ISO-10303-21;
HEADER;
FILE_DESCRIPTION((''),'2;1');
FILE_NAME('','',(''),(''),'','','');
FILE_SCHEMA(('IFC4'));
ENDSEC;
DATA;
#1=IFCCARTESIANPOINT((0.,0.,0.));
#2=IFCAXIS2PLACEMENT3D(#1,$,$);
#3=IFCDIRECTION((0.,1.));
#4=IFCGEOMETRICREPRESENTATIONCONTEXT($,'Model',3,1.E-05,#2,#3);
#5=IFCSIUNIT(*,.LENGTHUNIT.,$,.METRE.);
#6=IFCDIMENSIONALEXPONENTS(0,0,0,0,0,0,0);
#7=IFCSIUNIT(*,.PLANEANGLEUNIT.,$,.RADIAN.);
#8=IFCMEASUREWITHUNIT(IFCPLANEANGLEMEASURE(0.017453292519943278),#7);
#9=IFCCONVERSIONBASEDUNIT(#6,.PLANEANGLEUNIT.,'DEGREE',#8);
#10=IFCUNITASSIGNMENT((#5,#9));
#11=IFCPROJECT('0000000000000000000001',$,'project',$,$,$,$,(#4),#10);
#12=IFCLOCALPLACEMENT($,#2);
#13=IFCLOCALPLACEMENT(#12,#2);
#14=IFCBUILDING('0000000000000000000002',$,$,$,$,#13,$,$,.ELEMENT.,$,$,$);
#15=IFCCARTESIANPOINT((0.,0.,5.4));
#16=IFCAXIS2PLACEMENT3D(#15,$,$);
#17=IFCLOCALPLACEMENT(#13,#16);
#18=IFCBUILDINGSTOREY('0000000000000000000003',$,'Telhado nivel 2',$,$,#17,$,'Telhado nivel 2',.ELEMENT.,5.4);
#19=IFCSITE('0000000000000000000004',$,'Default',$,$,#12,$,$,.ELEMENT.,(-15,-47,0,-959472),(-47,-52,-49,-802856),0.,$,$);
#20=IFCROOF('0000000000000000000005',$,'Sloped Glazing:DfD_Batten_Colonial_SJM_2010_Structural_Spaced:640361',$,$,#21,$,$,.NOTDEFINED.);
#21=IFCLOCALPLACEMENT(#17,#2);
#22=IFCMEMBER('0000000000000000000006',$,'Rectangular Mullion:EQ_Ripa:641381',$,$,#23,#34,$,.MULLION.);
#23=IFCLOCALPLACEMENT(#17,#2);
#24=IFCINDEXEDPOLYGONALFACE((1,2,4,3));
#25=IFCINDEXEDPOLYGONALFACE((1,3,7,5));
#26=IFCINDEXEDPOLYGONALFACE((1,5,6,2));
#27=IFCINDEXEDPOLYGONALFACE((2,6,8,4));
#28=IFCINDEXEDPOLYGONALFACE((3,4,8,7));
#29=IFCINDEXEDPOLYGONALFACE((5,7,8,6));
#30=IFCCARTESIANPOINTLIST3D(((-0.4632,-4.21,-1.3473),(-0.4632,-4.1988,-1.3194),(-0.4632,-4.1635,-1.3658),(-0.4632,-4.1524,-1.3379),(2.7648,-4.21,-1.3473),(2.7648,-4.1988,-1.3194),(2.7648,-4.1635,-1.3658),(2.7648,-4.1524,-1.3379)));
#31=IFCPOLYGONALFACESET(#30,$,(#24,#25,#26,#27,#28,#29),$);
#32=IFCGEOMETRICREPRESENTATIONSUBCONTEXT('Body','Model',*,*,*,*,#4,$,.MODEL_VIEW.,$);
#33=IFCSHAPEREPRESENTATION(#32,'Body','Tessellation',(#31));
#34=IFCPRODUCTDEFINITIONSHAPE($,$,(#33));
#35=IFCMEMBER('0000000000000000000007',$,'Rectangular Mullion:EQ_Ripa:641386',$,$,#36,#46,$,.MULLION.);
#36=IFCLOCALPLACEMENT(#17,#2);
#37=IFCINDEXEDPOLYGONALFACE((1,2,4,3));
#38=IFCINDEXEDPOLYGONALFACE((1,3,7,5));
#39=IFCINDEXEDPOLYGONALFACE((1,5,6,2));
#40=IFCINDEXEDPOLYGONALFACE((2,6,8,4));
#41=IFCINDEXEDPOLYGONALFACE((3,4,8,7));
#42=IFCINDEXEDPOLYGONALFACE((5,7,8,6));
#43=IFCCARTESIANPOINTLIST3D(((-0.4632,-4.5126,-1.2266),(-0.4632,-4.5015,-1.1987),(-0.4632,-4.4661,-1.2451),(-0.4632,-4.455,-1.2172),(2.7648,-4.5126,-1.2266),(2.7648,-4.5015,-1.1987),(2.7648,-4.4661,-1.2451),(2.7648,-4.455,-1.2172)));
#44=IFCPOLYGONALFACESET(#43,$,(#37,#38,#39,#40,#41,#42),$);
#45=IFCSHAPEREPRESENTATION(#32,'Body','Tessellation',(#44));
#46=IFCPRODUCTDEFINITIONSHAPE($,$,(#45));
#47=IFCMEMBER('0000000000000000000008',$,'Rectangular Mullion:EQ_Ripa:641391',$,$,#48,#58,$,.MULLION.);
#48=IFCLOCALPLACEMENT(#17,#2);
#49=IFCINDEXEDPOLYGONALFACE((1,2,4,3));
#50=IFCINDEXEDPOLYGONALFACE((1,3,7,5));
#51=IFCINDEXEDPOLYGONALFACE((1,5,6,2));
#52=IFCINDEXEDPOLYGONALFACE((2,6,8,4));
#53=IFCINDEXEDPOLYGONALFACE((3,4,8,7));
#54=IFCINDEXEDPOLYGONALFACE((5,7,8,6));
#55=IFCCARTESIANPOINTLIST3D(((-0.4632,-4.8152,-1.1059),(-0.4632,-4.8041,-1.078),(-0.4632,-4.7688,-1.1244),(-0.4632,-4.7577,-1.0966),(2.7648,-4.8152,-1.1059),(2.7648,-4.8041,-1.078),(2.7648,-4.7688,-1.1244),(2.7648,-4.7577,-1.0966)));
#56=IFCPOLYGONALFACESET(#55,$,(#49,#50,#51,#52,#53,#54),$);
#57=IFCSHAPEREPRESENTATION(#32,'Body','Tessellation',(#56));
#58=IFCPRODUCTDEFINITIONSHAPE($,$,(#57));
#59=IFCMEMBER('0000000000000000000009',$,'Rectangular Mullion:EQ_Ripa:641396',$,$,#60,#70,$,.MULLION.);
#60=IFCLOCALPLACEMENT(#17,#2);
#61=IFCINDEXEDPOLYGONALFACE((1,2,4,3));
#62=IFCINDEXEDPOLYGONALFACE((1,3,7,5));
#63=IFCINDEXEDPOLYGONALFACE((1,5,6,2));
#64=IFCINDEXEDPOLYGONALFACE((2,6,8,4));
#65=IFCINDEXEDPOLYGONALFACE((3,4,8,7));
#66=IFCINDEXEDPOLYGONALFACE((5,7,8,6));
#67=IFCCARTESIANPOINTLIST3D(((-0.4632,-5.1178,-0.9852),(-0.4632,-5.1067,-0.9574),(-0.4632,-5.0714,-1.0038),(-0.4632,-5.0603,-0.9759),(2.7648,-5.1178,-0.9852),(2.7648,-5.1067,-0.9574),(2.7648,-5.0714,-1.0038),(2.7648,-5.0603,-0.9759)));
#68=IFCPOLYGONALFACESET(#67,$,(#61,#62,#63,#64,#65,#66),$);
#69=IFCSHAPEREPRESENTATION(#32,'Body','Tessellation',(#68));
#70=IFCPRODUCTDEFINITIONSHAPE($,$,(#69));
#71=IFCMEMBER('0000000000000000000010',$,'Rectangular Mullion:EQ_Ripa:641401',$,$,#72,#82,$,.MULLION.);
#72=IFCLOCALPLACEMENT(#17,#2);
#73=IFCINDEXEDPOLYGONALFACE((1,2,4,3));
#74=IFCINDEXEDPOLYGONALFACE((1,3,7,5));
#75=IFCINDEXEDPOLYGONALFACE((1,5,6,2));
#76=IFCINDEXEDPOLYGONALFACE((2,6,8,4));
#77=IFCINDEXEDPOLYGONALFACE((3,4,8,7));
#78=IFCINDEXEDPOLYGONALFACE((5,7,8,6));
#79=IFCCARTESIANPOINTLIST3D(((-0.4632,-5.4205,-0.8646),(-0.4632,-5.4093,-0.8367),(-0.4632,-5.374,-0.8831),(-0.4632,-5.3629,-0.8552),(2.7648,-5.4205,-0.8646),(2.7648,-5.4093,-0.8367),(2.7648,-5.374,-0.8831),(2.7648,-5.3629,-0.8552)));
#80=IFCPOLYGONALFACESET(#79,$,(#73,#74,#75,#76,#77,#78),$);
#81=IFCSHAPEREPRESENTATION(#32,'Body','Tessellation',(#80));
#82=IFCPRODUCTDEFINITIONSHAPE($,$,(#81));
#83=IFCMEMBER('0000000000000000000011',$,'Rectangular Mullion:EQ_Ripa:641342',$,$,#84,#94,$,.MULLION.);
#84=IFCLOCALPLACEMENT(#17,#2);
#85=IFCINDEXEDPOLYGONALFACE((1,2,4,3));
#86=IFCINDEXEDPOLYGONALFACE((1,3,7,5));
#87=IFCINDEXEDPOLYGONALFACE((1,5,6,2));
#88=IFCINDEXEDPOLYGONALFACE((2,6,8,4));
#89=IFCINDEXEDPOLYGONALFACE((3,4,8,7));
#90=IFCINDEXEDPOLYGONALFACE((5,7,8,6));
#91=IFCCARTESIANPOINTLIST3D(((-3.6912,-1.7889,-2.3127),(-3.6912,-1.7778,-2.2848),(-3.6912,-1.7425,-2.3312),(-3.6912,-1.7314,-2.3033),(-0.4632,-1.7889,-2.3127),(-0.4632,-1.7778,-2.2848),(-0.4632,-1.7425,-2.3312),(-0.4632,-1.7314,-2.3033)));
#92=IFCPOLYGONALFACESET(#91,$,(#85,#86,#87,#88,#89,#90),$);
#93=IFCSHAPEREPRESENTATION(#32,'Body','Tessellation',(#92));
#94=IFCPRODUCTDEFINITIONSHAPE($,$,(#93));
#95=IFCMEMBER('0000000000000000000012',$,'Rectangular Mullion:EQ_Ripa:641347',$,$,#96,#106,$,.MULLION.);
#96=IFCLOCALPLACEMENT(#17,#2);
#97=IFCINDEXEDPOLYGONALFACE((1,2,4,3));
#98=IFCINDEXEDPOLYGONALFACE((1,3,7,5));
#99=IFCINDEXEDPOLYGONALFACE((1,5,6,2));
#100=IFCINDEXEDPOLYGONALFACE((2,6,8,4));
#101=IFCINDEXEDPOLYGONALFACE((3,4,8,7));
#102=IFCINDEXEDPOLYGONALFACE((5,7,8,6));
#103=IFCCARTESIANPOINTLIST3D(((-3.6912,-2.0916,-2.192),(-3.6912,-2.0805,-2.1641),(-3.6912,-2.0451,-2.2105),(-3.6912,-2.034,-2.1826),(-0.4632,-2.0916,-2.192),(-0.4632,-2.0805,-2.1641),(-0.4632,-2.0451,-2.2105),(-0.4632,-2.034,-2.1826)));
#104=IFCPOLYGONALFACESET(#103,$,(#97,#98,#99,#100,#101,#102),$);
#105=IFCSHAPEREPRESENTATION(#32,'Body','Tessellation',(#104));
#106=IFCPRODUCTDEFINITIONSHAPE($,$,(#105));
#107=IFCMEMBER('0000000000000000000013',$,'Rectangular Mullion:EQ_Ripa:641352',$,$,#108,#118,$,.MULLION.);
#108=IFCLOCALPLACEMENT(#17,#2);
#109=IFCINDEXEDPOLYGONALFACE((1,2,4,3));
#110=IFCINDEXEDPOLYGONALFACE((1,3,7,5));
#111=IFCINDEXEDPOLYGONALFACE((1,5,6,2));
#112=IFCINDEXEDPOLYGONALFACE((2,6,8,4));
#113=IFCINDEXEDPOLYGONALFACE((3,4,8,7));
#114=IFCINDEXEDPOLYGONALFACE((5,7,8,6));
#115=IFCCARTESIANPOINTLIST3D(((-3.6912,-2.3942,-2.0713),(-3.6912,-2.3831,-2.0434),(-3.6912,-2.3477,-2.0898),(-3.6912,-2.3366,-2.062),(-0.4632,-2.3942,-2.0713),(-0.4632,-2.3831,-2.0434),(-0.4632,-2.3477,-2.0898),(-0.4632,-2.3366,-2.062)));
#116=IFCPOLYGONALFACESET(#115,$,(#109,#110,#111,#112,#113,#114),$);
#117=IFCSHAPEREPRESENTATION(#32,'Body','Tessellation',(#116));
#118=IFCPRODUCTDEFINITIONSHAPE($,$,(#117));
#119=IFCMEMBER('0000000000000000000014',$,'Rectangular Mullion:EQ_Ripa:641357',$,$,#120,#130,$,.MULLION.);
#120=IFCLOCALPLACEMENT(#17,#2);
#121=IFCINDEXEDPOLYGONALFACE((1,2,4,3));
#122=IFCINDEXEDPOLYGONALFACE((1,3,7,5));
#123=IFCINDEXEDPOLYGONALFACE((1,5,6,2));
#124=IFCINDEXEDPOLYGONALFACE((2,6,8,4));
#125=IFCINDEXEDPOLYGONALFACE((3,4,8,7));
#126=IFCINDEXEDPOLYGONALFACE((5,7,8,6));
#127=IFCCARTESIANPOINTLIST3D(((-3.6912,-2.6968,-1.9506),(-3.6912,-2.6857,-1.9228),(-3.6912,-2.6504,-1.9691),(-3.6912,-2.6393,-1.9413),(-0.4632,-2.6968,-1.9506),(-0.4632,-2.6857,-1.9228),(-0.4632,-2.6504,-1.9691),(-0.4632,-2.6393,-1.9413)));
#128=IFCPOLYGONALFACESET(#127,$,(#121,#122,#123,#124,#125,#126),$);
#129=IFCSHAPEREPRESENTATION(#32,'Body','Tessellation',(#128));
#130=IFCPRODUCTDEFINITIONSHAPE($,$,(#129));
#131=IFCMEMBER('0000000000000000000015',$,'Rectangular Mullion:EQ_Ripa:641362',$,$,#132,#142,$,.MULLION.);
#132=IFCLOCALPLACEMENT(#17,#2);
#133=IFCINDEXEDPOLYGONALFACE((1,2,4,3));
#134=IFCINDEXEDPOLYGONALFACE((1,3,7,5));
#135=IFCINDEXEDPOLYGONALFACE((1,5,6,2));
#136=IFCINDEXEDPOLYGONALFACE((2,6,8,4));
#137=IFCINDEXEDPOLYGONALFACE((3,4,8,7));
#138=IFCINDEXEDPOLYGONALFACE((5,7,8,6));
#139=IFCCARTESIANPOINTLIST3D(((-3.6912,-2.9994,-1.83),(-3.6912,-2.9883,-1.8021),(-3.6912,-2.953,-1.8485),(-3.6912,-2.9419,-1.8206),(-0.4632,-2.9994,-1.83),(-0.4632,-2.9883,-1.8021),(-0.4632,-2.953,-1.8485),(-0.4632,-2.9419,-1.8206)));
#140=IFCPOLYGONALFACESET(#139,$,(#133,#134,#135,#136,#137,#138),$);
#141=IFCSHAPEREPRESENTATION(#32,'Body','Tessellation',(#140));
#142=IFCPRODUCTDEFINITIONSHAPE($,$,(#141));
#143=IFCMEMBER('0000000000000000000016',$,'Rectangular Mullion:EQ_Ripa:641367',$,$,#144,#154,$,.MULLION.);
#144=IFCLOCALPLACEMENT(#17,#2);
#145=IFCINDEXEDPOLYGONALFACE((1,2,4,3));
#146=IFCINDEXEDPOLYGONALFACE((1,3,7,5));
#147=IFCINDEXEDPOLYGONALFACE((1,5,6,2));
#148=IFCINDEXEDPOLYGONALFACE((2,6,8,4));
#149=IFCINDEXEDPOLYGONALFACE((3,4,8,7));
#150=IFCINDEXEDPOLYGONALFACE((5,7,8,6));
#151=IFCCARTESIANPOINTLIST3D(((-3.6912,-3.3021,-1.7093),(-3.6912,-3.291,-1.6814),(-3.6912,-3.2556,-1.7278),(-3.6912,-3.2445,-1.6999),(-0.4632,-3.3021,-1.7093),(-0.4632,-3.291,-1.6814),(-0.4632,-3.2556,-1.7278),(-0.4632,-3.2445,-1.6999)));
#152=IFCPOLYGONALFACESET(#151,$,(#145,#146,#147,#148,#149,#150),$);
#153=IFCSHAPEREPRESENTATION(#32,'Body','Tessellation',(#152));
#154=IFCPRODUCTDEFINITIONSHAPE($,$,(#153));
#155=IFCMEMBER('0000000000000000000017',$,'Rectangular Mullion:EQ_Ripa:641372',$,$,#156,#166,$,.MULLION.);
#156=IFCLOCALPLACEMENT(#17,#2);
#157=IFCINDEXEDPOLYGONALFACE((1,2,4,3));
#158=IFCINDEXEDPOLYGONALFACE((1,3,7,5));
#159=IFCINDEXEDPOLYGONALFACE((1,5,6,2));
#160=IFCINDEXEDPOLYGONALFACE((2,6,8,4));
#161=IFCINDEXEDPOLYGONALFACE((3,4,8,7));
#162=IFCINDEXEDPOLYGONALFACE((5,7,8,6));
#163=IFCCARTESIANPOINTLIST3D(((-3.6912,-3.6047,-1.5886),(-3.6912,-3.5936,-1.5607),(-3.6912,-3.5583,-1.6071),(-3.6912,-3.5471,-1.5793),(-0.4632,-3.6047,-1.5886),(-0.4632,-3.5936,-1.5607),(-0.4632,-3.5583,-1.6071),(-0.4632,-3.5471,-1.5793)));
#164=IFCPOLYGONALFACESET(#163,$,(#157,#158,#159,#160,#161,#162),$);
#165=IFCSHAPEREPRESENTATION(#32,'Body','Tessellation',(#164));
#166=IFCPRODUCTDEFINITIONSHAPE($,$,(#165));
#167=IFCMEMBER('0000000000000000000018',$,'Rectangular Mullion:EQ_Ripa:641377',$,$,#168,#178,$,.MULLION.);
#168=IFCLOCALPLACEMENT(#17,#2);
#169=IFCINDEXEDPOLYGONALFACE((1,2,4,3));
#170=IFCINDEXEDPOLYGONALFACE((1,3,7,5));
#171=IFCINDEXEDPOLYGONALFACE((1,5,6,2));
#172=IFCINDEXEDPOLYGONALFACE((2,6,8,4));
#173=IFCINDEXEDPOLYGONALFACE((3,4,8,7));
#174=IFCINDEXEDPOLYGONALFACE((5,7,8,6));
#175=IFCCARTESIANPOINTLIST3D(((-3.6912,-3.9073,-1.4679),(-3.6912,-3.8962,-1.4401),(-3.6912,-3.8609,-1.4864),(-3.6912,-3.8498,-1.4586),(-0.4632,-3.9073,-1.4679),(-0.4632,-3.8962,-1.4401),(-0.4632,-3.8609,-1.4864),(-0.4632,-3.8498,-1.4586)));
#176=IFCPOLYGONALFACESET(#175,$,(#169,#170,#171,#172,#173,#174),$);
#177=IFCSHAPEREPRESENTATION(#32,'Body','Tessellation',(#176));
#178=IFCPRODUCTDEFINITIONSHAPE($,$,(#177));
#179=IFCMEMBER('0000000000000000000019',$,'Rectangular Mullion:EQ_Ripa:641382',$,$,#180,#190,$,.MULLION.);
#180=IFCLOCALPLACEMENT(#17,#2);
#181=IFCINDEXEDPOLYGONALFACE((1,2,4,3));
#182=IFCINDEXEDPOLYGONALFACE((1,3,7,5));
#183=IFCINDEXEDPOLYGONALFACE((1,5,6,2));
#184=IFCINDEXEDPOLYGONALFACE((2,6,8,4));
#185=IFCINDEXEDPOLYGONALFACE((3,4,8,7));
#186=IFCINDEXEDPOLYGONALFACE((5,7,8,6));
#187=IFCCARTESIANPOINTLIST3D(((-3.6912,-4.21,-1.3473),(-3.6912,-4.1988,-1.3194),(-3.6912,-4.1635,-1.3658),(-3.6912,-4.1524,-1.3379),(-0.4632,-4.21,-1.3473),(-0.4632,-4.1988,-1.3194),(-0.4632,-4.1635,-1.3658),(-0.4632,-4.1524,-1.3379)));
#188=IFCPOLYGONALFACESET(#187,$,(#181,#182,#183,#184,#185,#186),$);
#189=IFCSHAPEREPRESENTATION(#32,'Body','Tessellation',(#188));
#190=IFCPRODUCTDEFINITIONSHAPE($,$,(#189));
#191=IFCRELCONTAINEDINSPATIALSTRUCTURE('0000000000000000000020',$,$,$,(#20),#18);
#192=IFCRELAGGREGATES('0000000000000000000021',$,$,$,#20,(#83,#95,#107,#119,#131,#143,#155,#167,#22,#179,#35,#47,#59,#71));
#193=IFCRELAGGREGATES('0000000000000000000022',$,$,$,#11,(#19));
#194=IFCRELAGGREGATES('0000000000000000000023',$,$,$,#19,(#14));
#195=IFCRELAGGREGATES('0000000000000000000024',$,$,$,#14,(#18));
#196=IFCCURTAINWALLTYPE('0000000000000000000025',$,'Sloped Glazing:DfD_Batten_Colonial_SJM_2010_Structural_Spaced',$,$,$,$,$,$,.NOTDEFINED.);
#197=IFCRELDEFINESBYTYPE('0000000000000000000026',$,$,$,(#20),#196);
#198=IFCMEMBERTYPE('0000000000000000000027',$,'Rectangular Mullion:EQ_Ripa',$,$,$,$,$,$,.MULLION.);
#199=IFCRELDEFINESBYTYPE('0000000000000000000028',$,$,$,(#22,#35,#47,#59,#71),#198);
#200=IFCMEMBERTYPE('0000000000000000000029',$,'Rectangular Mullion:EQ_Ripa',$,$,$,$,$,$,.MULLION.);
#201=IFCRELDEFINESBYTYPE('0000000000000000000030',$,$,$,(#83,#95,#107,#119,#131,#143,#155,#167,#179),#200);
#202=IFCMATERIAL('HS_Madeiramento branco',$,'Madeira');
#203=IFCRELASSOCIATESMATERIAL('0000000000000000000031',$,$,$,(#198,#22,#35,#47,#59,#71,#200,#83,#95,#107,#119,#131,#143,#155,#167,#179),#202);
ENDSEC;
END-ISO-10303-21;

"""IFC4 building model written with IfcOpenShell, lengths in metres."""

from ifc_helpers import new_model, entity, si_unit, converted_unit, direction, frame, origin, place, context, subcontext, project, spatial, indexed_curve, outline, extrude, source, transform, mapped, material, type_object, type_shapes, element, aggregate, save


model = new_model("IFC4")

# Units and contexts
model_context = context("Model", 3, precision=1e-05, world=origin(), true_north=direction((0.0, 1.0)))
body_context = subcontext(model_context, "Body", "Model", "MODEL_VIEW")
ifc_project = project(units=[si_unit("LENGTHUNIT", "METRE"), converted_unit("PLANEANGLEUNIT", "DEGREE", entity("IfcPlaneAngleMeasure", 0.017453292519943278), si_unit("PLANEANGLEUNIT", "RADIAN"), dimensions=[0, 0, 0, 0, 0, 0, 0])], contexts=[model_context])

# Site, building, storey
site_placement = place(None, origin())
site = spatial("IfcSite", under=ifc_project, at=site_placement, Name="Default", CompositionType="ELEMENT", RefLatitude=(-15, -47, 0, -959472), RefLongitude=(-47, -52, -49, -802856), RefElevation=0.0)
building_placement = place(site_placement, origin())
building = spatial("IfcBuilding", under=site, at=building_placement, CompositionType="ELEMENT")
storey_placement = place(building_placement, frame((0.0, 0.0, 5.4)))
storey = spatial("IfcBuildingStorey", under=building, at=storey_placement, Name="Telhado nivel 2", LongName="Telhado nivel 2", CompositionType="ELEMENT", Elevation=5.4)

# Roof, members
curtain_wall_type = type_object("IfcCurtainWallType", Name="Sloped Glazing:DfD_Batten_Colonial_SJM_2010_Structural_Spaced", PredefinedType="NOTDEFINED")
ifc_material = material(Name="HS_Madeiramento branco", Category="Madeira")
roof_1_placement = place(storey_placement, frame((0.0, 0.0, -5.4)))
roof_1 = element("IfcRoof", 1, at=roof_1_placement, inside=storey, type_object=curtain_wall_type, Name="Sloped Glazing:DfD_Batten_Colonial_SJM_2010_Structural_Spaced:640361", PredefinedType="NOTDEFINED")
member_type_1 = type_object("IfcMemberType", Name="Rectangular Mullion:EQ_Ripa", PredefinedType="MULLION", material=ifc_material)
shared_shape_1 = source(origin(), body_context, "Body", "SweptSolid", [
    extrude(outline(indexed_curve([(-0.025, -0.015), (0.025, -0.015), (0.025, 0.015), (-0.025, 0.015), (-0.025, -0.015)], self_intersect=False)), frame((0.0, 0.0, -3.228), z_axis=(0.0, 0.0, 1.0), x_axis=(-1.0, 0.0, 0.0)), (0.0, 0.0, 1.0), 3.228),
])
type_shapes(member_type_1, [shared_shape_1])
member_1_placement = place(roof_1_placement, frame((2.7648, -4.1812, 4.0574), z_axis=(1.0, 0.0, 0.0), x_axis=(0.0, -0.928874, 0.370395)))
member_1 = element("IfcMember", 2, at=member_1_placement, type_object=member_type_1, material=ifc_material, Name="Rectangular Mullion:EQ_Ripa:641381", PredefinedType="MULLION", context=body_context, shape_type="MappedRepresentation", body=[
    mapped(shared_shape_1, transform((0.0, 0.0, 0.0), scale=1.0)),
])
member_2_placement = place(roof_1_placement, frame((2.7648, -4.4838, 4.1781), z_axis=(1.0, 0.0, 0.0), x_axis=(0.0, -0.928874, 0.370395)))
member_2 = element("IfcMember", 3, at=member_2_placement, type_object=member_type_1, material=ifc_material, Name="Rectangular Mullion:EQ_Ripa:641386", PredefinedType="MULLION", context=body_context, shape_type="MappedRepresentation", body=[
    mapped(shared_shape_1, transform((0.0, 0.0, 0.0), scale=1.0)),
])
member_3_placement = place(roof_1_placement, frame((2.7648, -4.7864, 4.2988), z_axis=(1.0, 0.0, 0.0), x_axis=(0.0, -0.928874, 0.370395)))
member_3 = element("IfcMember", 4, at=member_3_placement, type_object=member_type_1, material=ifc_material, Name="Rectangular Mullion:EQ_Ripa:641391", PredefinedType="MULLION", context=body_context, shape_type="MappedRepresentation", body=[
    mapped(shared_shape_1, transform((0.0, 0.0, 0.0), scale=1.0)),
])
member_4_placement = place(roof_1_placement, frame((2.7648, -5.0891, 4.4194), z_axis=(1.0, 0.0, 0.0), x_axis=(0.0, -0.928874, 0.370395)))
member_4 = element("IfcMember", 5, at=member_4_placement, type_object=member_type_1, material=ifc_material, Name="Rectangular Mullion:EQ_Ripa:641396", PredefinedType="MULLION", context=body_context, shape_type="MappedRepresentation", body=[
    mapped(shared_shape_1, transform((0.0, 0.0, 0.0), scale=1.0)),
])
member_5_placement = place(roof_1_placement, frame((2.7648, -5.3917, 4.5401), z_axis=(1.0, 0.0, 0.0), x_axis=(0.0, -0.928874, 0.370395)))
member_5 = element("IfcMember", 6, at=member_5_placement, type_object=member_type_1, material=ifc_material, Name="Rectangular Mullion:EQ_Ripa:641401", PredefinedType="MULLION", context=body_context, shape_type="MappedRepresentation", body=[
    mapped(shared_shape_1, transform((0.0, 0.0, 0.0), scale=1.0)),
])
member_type_2 = type_object("IfcMemberType", Name="Rectangular Mullion:EQ_Ripa", PredefinedType="MULLION", material=ifc_material)
shared_shape_2 = source(origin(), body_context, "Body", "SweptSolid", [
    extrude(outline(indexed_curve([(-0.025, -0.015), (0.025, -0.015), (0.025, 0.015), (-0.025, 0.015), (-0.025, -0.015)], self_intersect=False)), frame((0.0, 0.0, -3.228), z_axis=(0.0, 0.0, 1.0), x_axis=(-1.0, 0.0, 0.0)), (0.0, 0.0, 1.0), 3.228),
])
type_shapes(member_type_2, [shared_shape_2])
member_6_placement = place(roof_1_placement, frame((-0.4632, -1.7602, 3.092), z_axis=(1.0, 0.0, 0.0), x_axis=(0.0, -0.928874, 0.370395)))
member_6 = element("IfcMember", 7, at=member_6_placement, type_object=member_type_2, material=ifc_material, Name="Rectangular Mullion:EQ_Ripa:641342", PredefinedType="MULLION", context=body_context, shape_type="MappedRepresentation", body=[
    mapped(shared_shape_2, transform((0.0, 0.0, 0.0), scale=1.0)),
])
member_7_placement = place(roof_1_placement, frame((-0.4632, -2.0628, 3.2127), z_axis=(1.0, 0.0, 0.0), x_axis=(0.0, -0.928874, 0.370395)))
member_7 = element("IfcMember", 8, at=member_7_placement, type_object=member_type_2, material=ifc_material, Name="Rectangular Mullion:EQ_Ripa:641347", PredefinedType="MULLION", context=body_context, shape_type="MappedRepresentation", body=[
    mapped(shared_shape_2, transform((0.0, 0.0, 0.0), scale=1.0)),
])
member_8_placement = place(roof_1_placement, frame((-0.4632, -2.3654, 3.3334), z_axis=(1.0, 0.0, 0.0), x_axis=(0.0, -0.928874, 0.370395)))
member_8 = element("IfcMember", 9, at=member_8_placement, type_object=member_type_2, material=ifc_material, Name="Rectangular Mullion:EQ_Ripa:641352", PredefinedType="MULLION", context=body_context, shape_type="MappedRepresentation", body=[
    mapped(shared_shape_2, transform((0.0, 0.0, 0.0), scale=1.0)),
])
member_9_placement = place(roof_1_placement, frame((-0.4632, -2.668, 3.454), z_axis=(1.0, 0.0, 0.0), x_axis=(0.0, -0.928874, 0.370395)))
member_9 = element("IfcMember", 10, at=member_9_placement, type_object=member_type_2, material=ifc_material, Name="Rectangular Mullion:EQ_Ripa:641357", PredefinedType="MULLION", context=body_context, shape_type="MappedRepresentation", body=[
    mapped(shared_shape_2, transform((0.0, 0.0, 0.0), scale=1.0)),
])
member_10_placement = place(roof_1_placement, frame((-0.4632, -2.9707, 3.5747), z_axis=(1.0, 0.0, 0.0), x_axis=(0.0, -0.928874, 0.370395)))
member_10 = element("IfcMember", 11, at=member_10_placement, type_object=member_type_2, material=ifc_material, Name="Rectangular Mullion:EQ_Ripa:641362", PredefinedType="MULLION", context=body_context, shape_type="MappedRepresentation", body=[
    mapped(shared_shape_2, transform((0.0, 0.0, 0.0), scale=1.0)),
])
member_11_placement = place(roof_1_placement, frame((-0.4632, -3.2733, 3.6954), z_axis=(1.0, 0.0, 0.0), x_axis=(0.0, -0.928874, 0.370395)))
member_11 = element("IfcMember", 12, at=member_11_placement, type_object=member_type_2, material=ifc_material, Name="Rectangular Mullion:EQ_Ripa:641367", PredefinedType="MULLION", context=body_context, shape_type="MappedRepresentation", body=[
    mapped(shared_shape_2, transform((0.0, 0.0, 0.0), scale=1.0)),
])
member_12_placement = place(roof_1_placement, frame((-0.4632, -3.5759, 3.8161), z_axis=(1.0, 0.0, 0.0), x_axis=(0.0, -0.928874, 0.370395)))
member_12 = element("IfcMember", 13, at=member_12_placement, type_object=member_type_2, material=ifc_material, Name="Rectangular Mullion:EQ_Ripa:641372", PredefinedType="MULLION", context=body_context, shape_type="MappedRepresentation", body=[
    mapped(shared_shape_2, transform((0.0, 0.0, 0.0), scale=1.0)),
])
member_13_placement = place(roof_1_placement, frame((-0.4632, -3.8785, 3.9367), z_axis=(1.0, 0.0, 0.0), x_axis=(0.0, -0.928874, 0.370395)))
member_13 = element("IfcMember", 14, at=member_13_placement, type_object=member_type_2, material=ifc_material, Name="Rectangular Mullion:EQ_Ripa:641377", PredefinedType="MULLION", context=body_context, shape_type="MappedRepresentation", body=[
    mapped(shared_shape_2, transform((0.0, 0.0, 0.0), scale=1.0)),
])
member_14_placement = place(roof_1_placement, frame((-0.4632, -4.1812, 4.0574), z_axis=(1.0, 0.0, 0.0), x_axis=(0.0, -0.928874, 0.370395)))
member_14 = element("IfcMember", 15, at=member_14_placement, type_object=member_type_2, material=ifc_material, Name="Rectangular Mullion:EQ_Ripa:641382", PredefinedType="MULLION", context=body_context, shape_type="MappedRepresentation", body=[
    mapped(shared_shape_2, transform((0.0, 0.0, 0.0), scale=1.0)),
])
aggregate(roof_1, [member_6, member_7, member_8, member_9, member_10, member_11, member_12, member_13, member_1, member_14, member_2, member_3, member_4, member_5])

save(model, "model.ifc")
